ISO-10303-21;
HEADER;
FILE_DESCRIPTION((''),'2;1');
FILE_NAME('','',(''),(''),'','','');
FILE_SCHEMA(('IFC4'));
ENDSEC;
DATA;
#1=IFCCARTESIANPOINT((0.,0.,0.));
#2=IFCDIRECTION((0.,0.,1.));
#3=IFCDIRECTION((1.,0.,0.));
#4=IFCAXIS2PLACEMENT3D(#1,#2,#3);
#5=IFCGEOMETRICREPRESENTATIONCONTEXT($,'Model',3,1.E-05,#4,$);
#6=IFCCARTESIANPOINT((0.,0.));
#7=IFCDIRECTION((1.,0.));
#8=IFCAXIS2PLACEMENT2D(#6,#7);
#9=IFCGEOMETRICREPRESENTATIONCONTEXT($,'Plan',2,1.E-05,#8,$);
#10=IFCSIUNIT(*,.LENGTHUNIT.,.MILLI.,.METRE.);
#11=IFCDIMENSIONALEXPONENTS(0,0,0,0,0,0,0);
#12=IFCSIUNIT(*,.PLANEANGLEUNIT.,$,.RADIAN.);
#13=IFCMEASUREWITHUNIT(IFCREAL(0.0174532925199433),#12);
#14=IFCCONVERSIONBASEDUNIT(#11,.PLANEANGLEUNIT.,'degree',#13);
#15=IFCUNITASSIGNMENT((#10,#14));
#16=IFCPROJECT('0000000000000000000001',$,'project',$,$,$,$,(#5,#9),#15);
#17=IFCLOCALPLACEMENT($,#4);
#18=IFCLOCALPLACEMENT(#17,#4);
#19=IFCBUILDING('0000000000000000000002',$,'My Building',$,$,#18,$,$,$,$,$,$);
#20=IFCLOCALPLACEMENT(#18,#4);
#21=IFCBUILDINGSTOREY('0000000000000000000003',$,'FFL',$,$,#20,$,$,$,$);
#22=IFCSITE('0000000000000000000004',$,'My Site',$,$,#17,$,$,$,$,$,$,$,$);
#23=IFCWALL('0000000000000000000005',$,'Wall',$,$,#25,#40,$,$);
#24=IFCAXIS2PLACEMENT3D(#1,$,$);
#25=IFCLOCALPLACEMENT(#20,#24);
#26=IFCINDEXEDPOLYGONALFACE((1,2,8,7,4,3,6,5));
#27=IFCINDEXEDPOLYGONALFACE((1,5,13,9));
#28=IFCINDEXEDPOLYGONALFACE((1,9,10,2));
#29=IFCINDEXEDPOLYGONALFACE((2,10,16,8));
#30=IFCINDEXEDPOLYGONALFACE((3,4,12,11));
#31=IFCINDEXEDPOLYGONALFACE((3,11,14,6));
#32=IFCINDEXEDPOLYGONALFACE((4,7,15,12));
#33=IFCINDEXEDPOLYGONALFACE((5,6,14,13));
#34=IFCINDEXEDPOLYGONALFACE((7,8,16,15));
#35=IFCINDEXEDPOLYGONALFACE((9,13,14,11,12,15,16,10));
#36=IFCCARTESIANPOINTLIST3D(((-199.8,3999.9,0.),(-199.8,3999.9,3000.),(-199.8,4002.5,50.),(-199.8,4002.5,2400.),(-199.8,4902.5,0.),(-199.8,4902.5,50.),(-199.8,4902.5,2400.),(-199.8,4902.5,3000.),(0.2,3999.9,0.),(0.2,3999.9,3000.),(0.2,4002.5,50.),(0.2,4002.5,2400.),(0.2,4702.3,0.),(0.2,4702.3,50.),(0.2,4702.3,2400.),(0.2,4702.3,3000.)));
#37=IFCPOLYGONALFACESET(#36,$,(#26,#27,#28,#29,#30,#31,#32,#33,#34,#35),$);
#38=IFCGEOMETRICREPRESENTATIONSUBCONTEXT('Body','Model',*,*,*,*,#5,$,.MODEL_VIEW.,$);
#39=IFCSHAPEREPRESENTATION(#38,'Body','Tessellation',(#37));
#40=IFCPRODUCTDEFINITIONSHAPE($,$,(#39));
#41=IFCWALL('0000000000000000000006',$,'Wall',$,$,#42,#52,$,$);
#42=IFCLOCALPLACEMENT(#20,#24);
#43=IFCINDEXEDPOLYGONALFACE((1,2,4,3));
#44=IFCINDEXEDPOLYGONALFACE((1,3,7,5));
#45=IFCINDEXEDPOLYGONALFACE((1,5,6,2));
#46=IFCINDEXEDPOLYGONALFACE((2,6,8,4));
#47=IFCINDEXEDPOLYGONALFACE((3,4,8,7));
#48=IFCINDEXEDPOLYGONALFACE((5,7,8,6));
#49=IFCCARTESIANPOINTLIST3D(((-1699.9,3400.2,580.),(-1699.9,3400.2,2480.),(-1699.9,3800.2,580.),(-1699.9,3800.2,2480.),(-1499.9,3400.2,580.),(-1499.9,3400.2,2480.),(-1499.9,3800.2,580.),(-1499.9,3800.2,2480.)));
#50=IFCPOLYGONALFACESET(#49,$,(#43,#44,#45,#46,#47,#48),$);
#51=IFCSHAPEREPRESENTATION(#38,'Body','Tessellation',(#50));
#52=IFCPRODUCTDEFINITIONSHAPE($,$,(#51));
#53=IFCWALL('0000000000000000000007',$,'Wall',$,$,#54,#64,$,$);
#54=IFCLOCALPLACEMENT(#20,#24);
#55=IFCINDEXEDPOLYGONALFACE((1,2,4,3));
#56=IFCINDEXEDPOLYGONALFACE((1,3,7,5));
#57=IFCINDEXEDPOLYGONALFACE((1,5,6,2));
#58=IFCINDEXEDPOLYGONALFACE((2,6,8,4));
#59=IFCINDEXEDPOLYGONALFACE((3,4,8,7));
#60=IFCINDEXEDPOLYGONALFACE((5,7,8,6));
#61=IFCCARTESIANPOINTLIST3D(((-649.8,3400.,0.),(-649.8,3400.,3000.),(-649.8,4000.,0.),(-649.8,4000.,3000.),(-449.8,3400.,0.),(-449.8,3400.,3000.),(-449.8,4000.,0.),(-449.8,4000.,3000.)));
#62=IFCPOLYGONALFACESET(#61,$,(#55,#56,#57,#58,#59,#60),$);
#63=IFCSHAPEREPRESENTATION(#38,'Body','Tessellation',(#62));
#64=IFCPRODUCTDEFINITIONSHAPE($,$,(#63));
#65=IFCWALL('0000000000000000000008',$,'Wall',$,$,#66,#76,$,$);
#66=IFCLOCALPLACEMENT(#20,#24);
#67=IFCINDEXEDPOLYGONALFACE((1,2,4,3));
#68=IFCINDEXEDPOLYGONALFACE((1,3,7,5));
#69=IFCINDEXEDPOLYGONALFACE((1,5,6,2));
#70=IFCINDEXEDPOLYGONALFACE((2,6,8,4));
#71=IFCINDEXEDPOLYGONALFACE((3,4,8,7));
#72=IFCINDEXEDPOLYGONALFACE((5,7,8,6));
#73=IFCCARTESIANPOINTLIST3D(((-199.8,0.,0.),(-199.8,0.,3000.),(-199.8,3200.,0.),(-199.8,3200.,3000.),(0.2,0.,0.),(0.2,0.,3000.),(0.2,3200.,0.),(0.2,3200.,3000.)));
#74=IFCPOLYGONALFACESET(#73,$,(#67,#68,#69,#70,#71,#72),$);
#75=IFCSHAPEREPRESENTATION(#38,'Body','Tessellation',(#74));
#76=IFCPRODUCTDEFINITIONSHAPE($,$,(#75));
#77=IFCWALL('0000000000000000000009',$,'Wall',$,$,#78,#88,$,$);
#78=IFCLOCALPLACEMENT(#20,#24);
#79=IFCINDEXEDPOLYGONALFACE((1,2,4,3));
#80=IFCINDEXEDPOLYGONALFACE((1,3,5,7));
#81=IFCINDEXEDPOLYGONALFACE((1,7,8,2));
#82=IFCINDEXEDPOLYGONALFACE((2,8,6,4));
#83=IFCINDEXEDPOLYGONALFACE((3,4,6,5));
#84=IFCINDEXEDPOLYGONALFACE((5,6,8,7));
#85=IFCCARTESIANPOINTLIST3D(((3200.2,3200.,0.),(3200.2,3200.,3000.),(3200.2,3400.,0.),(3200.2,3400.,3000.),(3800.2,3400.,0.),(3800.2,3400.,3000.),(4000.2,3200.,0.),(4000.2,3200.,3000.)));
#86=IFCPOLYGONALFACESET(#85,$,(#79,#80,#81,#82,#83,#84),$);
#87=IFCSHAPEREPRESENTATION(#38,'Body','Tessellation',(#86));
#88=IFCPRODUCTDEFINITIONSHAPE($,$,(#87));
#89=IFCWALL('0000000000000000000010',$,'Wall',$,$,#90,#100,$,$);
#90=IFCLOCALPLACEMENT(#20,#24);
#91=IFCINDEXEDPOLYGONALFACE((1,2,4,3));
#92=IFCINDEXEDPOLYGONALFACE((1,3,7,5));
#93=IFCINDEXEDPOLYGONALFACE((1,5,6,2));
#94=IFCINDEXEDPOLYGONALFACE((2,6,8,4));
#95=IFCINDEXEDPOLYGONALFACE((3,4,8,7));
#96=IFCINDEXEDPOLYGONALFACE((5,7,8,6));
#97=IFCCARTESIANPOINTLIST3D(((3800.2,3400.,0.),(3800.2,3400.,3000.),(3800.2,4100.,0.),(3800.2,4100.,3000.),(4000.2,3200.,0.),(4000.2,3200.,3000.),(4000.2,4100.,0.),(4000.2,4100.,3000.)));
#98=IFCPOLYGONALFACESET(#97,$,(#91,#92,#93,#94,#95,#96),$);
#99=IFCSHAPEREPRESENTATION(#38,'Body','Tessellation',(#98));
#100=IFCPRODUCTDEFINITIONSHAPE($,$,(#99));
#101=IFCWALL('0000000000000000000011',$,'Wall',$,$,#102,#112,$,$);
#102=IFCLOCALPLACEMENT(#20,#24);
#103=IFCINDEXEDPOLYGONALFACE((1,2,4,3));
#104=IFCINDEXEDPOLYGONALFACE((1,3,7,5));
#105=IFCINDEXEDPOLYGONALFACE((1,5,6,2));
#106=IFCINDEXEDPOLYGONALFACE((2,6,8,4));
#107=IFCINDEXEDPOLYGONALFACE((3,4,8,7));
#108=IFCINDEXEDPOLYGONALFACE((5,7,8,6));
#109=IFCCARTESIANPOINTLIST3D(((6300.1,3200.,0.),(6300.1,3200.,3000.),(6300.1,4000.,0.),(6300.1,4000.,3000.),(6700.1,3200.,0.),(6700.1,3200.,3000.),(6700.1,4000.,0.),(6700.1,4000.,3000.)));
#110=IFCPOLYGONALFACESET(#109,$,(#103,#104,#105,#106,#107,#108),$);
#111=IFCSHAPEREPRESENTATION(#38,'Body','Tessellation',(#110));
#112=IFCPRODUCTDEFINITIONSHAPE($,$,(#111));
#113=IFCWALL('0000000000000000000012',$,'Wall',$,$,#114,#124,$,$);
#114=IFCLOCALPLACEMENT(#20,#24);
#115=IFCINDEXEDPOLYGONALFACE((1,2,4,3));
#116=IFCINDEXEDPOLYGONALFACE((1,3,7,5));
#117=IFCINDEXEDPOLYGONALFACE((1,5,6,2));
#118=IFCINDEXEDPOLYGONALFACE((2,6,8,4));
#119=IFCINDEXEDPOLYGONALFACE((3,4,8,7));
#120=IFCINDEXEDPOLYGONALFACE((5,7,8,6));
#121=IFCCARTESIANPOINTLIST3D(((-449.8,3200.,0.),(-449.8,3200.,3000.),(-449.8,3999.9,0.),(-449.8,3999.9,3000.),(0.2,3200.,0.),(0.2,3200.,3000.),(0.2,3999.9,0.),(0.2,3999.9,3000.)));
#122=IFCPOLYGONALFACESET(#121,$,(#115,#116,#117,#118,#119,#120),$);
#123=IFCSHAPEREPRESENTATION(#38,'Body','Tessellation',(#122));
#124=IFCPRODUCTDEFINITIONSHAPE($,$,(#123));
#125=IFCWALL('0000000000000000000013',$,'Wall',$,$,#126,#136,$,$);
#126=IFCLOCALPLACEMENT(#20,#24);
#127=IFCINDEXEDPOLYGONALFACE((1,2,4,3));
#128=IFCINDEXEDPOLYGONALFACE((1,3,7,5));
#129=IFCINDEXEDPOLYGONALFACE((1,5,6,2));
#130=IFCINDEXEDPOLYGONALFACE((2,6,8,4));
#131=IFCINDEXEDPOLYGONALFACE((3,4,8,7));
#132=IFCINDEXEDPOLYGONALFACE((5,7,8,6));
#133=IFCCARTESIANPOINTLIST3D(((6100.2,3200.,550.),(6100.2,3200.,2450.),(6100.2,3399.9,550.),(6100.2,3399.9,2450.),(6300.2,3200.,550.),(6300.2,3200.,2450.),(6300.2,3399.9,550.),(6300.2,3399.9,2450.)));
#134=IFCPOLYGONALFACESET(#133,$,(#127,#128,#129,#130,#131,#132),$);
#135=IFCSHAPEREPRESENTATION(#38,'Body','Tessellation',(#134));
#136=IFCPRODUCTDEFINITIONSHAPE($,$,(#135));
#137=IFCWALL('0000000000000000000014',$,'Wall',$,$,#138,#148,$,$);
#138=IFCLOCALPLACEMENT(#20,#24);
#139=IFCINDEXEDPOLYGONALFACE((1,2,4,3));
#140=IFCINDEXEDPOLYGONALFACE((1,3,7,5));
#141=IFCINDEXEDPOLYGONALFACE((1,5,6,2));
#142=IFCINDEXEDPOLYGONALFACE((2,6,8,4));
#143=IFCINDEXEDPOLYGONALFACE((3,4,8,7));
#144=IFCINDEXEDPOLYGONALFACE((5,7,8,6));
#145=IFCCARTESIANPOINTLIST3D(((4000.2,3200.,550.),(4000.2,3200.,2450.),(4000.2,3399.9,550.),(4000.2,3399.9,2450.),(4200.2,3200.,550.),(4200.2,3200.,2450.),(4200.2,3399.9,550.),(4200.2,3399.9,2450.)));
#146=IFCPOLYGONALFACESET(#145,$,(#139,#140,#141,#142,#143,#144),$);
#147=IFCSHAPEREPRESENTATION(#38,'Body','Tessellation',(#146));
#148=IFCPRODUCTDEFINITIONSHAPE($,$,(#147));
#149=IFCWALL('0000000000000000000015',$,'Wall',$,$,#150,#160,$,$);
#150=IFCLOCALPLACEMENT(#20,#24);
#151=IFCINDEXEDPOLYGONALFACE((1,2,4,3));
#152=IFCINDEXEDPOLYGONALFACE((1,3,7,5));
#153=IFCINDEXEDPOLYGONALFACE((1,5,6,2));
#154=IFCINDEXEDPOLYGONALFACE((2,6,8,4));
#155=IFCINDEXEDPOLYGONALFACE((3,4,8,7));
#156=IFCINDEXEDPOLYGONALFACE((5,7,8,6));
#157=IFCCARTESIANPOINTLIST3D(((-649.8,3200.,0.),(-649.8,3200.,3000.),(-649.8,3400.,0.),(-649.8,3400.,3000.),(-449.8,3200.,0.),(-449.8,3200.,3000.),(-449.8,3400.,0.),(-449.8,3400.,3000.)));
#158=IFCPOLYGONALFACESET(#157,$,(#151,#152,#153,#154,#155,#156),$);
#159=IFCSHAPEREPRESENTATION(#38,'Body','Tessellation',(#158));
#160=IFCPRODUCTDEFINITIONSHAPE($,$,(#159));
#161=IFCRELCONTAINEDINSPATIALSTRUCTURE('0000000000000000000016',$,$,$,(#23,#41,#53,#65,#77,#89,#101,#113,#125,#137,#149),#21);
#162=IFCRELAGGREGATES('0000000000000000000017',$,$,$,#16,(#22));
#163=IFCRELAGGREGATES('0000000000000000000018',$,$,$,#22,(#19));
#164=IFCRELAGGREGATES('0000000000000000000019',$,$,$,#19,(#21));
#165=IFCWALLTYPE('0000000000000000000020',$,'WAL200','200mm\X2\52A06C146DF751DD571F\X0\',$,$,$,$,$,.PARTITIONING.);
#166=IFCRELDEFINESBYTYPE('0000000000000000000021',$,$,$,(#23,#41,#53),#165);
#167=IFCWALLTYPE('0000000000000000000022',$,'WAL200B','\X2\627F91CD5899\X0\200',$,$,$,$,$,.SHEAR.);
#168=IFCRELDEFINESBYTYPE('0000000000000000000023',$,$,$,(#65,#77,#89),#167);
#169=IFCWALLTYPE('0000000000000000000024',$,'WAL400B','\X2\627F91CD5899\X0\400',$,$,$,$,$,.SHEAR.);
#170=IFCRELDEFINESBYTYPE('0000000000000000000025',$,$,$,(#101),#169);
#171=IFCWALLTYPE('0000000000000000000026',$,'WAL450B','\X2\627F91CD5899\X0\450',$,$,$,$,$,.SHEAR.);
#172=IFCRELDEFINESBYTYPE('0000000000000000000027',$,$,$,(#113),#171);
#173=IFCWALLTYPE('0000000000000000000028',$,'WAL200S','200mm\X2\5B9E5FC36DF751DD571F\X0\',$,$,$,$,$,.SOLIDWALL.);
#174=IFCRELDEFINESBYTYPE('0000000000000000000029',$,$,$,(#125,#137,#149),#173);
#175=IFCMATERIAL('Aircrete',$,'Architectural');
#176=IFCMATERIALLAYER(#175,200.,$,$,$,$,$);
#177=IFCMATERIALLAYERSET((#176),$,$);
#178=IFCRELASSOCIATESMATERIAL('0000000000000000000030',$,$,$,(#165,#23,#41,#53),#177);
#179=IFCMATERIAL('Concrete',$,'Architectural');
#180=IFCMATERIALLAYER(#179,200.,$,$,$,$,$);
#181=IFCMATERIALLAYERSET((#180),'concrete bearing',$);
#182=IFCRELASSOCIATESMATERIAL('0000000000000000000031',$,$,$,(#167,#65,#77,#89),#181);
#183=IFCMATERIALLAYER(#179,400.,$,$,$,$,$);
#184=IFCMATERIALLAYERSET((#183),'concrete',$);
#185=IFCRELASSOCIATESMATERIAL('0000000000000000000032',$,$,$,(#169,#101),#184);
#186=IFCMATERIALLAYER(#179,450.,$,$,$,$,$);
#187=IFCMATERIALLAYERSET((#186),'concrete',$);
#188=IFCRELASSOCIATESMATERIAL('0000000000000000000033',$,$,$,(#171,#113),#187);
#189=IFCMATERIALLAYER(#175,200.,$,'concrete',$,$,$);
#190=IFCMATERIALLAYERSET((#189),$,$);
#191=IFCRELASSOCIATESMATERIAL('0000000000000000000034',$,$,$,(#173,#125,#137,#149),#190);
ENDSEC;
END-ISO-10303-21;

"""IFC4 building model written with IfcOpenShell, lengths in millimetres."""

from ifc_helpers import new_model, entity, si_unit, converted_unit, frame, origin_with_axes, origin_2d_with_axis, place, context, subcontext, project, spatial, line, indexed_curve, outline, extrude, material, layer, layer_set, layer_usage, type_object, element, save


model = new_model("IFC4")

# Units and contexts
model_context = context("Model", 3, precision=1e-05, world=origin_with_axes())
plan_context = context("Plan", 2, precision=1e-05, world=origin_2d_with_axis())
body_context_1 = subcontext(model_context, "Body", "Model", "MODEL_VIEW")
ifc_project = project(units=[si_unit("LENGTHUNIT", "METRE", prefix="MILLI"), converted_unit("PLANEANGLEUNIT", "degree", entity("IfcReal", 0.0174532925199433), si_unit("PLANEANGLEUNIT", "RADIAN"), dimensions=[0, 0, 0, 0, 0, 0, 0])], contexts=[model_context, plan_context])

# Site, building, storey
site_placement = place(None, origin_with_axes())
site = spatial("IfcSite", under=ifc_project, at=site_placement, Name="My Site")
building_placement = place(site_placement, origin_with_axes())
building = spatial("IfcBuilding", under=site, at=building_placement, Name="My Building")
storey_placement = place(building_placement, origin_with_axes())
storey = spatial("IfcBuildingStorey", under=building, at=storey_placement, Name="FFL")

# Shared definitions
ifc_material_1 = material(Name="Aircrete", Category="Architectural")

# Shared definitions
ifc_layer_1 = layer(ifc_material_1, 200.0)
ifc_layer_set_1 = layer_set([ifc_layer_1])
wall_type_1 = type_object("IfcWallType", Name="WAL200", Description="200mm加气混凝土", PredefinedType="PARTITIONING", material=ifc_layer_set_1)

# Wall, opening
ifc_layer_usage_1 = layer_usage(ifc_layer_set_1, "AXIS2", "NEGATIVE", 0.0)
wall_1_placement = place(storey_placement, frame((-199.8, 3999.9, 0.0), z_axis=(0.0, 0.0, 1.0), x_axis=(0.000001, 1.0, 0.0)))
wall_1 = element("IfcWall", 1, at=wall_1_placement, inside=storey, type_object=wall_type_1, material=ifc_layer_usage_1, Name="Wall", context=body_context_1, shape_type="SweptSolid", body=[
    extrude(outline(indexed_curve([(0.0, -200.0), (0.0, 0.0), (902.5, 0.0), (702.4, -200.0)], segments=[line(1, 2, 3, 4, 1)])), origin_with_axes(), (0.0, 0.0, 1.0), 3000.0),
])
opening_1_placement = place(wall_1_placement, frame((2.6, 200.0, 50.0), z_axis=(0.0, 0.0, 1.0), x_axis=(0.0, -1.0, 0.0)))
element("IfcOpeningElement", 2, at=opening_1_placement, cuts=wall_1, PredefinedType="OPENING", context=body_context_1, shape_type="SweptSolid", body=[
    extrude(outline(indexed_curve([(0.0, 0.0), (4600.0, 0.0), (4600.0, 1146.7), (0.0, 1146.7), (0.0, 0.0)])), origin_with_axes(), (0.0, 0.0, 1.0), 2350.0),
])

# Walls
ifc_layer_usage_2 = layer_usage(ifc_layer_set_1, "AXIS2", "NEGATIVE", 0.0)
wall_2_placement = place(storey_placement, frame((-1699.9, 3400.2, 580.0), z_axis=(0.0, 0.0, 1.0), x_axis=(0.0, 1.0, 0.0)))
element("IfcWall", 3, at=wall_2_placement, inside=storey, type_object=wall_type_1, material=ifc_layer_usage_2, Name="Wall", context=body_context_1, shape_type="SweptSolid", body=[
    extrude(outline(indexed_curve([(0.0, -200.0), (0.0, 0.0), (400.0, 0.0), (400.0, -200.0)], segments=[line(1, 2, 3, 4, 1)])), origin_with_axes(), (0.0, 0.0, 1.0), 1900.0),
])
ifc_layer_usage_3 = layer_usage(ifc_layer_set_1, "AXIS2", "NEGATIVE", 0.0)
wall_3_placement = place(storey_placement, frame((-649.8, 3400.0, 0.0), z_axis=(0.0, 0.0, 1.0), x_axis=(0.0, 1.0, 0.0)))
element("IfcWall", 4, at=wall_3_placement, inside=storey, type_object=wall_type_1, material=ifc_layer_usage_3, Name="Wall", context=body_context_1, shape_type="SweptSolid", body=[
    extrude(outline(indexed_curve([(0.0, -200.0), (0.0, 0.0), (600.0, 0.0), (600.0, -200.0)], segments=[line(1, 2, 3, 4, 1)])), origin_with_axes(), (0.0, 0.0, 1.0), 3000.0),
])
ifc_material_2 = material(Name="Concrete", Category="Architectural")
ifc_layer_2 = layer(ifc_material_2, 200.0)
ifc_layer_set_2 = layer_set([ifc_layer_2], Name="concrete bearing")
ifc_layer_usage_4 = layer_usage(ifc_layer_set_2, "AXIS2", "NEGATIVE", 0.0)
wall_type_2 = type_object("IfcWallType", Name="WAL200B", Description="承重墙200", PredefinedType="SHEAR", material=ifc_layer_set_2)
wall_4_placement = place(storey_placement, frame((0.2, 3200.0, 0.0), z_axis=(0.0, 0.0, 1.0), x_axis=(0.0, -1.0, 0.0)))
element("IfcWall", 5, at=wall_4_placement, inside=storey, type_object=wall_type_2, material=ifc_layer_usage_4, Name="Wall", context=body_context_1, shape_type="SweptSolid", body=[
    extrude(outline(indexed_curve([(0.0, -200.0), (0.0, 0.0), (3200.0, 0.0), (3200.0, -200.0)], segments=[line(1, 2, 3, 4, 1)])), origin_with_axes(), (0.0, 0.0, 1.0), 3000.0),
])
ifc_layer_usage_5 = layer_usage(ifc_layer_set_2, "AXIS2", "NEGATIVE", 0.0)
wall_5_placement = place(storey_placement, frame((3800.2, 3200.0, 0.0), z_axis=(0.0, 0.0, 1.0), x_axis=(-1.0, 0.0, 0.0)))
element("IfcWall", 6, at=wall_5_placement, inside=storey, type_object=wall_type_2, material=ifc_layer_usage_5, Name="Wall", context=body_context_1, shape_type="SweptSolid", body=[
    extrude(outline(indexed_curve([(0.0, -200.0), (-200.0, 0.0), (600.0, 0.0), (600.0, -200.0)], segments=[line(1, 2, 3, 4, 1)])), origin_with_axes(), (0.0, 0.0, 1.0), 3000.0),
])
ifc_layer_usage_6 = layer_usage(ifc_layer_set_2, "AXIS2", "NEGATIVE", 0.0)
wall_6_placement = place(storey_placement, frame((3800.2, 3200.0, 0.0), z_axis=(0.0, 0.0, 1.0), x_axis=(0.0, 1.0, 0.0)))
element("IfcWall", 7, at=wall_6_placement, inside=storey, type_object=wall_type_2, material=ifc_layer_usage_6, Name="Wall", context=body_context_1, shape_type="SweptSolid", body=[
    extrude(outline(indexed_curve([(0.0, -200.0), (200.0, 0.0), (900.0, 0.0), (900.0, -200.0)], segments=[line(1, 2, 3, 4, 1)])), origin_with_axes(), (0.0, 0.0, 1.0), 3000.0),
])
ifc_layer_3 = layer(ifc_material_2, 400.0)
ifc_layer_set_3 = layer_set([ifc_layer_3], Name="concrete")
ifc_layer_usage_7 = layer_usage(ifc_layer_set_3, "AXIS2", "POSITIVE", 0.0)
wall_type_3 = type_object("IfcWallType", Name="WAL400B", Description="承重墙400", PredefinedType="SHEAR", material=ifc_layer_set_3)
wall_7_placement = place(storey_placement, frame((6700.1, 3200.0, 0.0), z_axis=(0.0, 0.0, 1.0), x_axis=(0.000001, 1.0, 0.0)))
element("IfcWall", 8, at=wall_7_placement, inside=storey, type_object=wall_type_3, material=ifc_layer_usage_7, Name="Wall", context=body_context_1, shape_type="SweptSolid", body=[
    extrude(outline(indexed_curve([(0.0, 0.0), (0.0, 400.0), (800.0, 400.0), (800.0, 0.0)], segments=[line(1, 2, 3, 4, 1)])), origin_with_axes(), (0.0, 0.0, 1.0), 3000.0),
])
ifc_layer_4 = layer(ifc_material_2, 450.0)
ifc_layer_set_4 = layer_set([ifc_layer_4], Name="concrete")
ifc_layer_usage_8 = layer_usage(ifc_layer_set_4, "AXIS2", "POSITIVE", 0.0)
wall_type_4 = type_object("IfcWallType", Name="WAL450B", Description="承重墙450", PredefinedType="SHEAR", material=ifc_layer_set_4)
wall_8_placement = place(storey_placement, frame((0.2, 3200.0, 0.0), z_axis=(0.0, 0.0, 1.0), x_axis=(0.0, 1.0, 0.0)))
element("IfcWall", 9, at=wall_8_placement, inside=storey, type_object=wall_type_4, material=ifc_layer_usage_8, Name="Wall", context=body_context_1, shape_type="SweptSolid", body=[
    extrude(outline(indexed_curve([(0.0, 0.0), (0.0, 450.0), (799.9, 450.0), (799.9, 0.0)], segments=[line(1, 2, 3, 4, 1)])), origin_with_axes(), (0.0, 0.0, 1.0), 3000.0),
])
ifc_layer_5 = layer(ifc_material_1, 200.0, Name="concrete")
ifc_layer_set_5 = layer_set([ifc_layer_5])
ifc_layer_usage_9 = layer_usage(ifc_layer_set_5, "AXIS2", "NEGATIVE", 0.0)
wall_type_5 = type_object("IfcWallType", Name="WAL200S", Description="200mm实心混凝土", PredefinedType="SOLIDWALL", material=ifc_layer_set_5)
wall_9_placement = place(storey_placement, frame((6100.2, 3200.0, 550.0), z_axis=(0.0, 0.0, 1.0), x_axis=(-0.000002, 1.0, 0.0)))
element("IfcWall", 10, at=wall_9_placement, inside=storey, type_object=wall_type_5, material=ifc_layer_usage_9, Name="Wall", context=body_context_1, shape_type="SweptSolid", body=[
    extrude(outline(indexed_curve([(0.0, -200.0), (0.0, 0.0), (200.0, 0.0), (200.0, -200.0)], segments=[line(1, 2, 3, 4, 1)])), origin_with_axes(), (0.0, 0.0, 1.0), 1900.0),
])
ifc_layer_usage_10 = layer_usage(ifc_layer_set_5, "AXIS2", "NEGATIVE", 0.0)
wall_10_placement = place(storey_placement, frame((4200.2, 3399.9, 550.0), z_axis=(0.0, 0.0, 1.0), x_axis=(0.000002, -1.0, 0.0)))
element("IfcWall", 11, at=wall_10_placement, inside=storey, type_object=wall_type_5, material=ifc_layer_usage_10, Name="Wall", context=body_context_1, shape_type="SweptSolid", body=[
    extrude(outline(indexed_curve([(0.0, -200.0), (0.0, 0.0), (200.0, 0.0), (200.0, -200.0)], segments=[line(1, 2, 3, 4, 1)])), origin_with_axes(), (0.0, 0.0, 1.0), 1900.0),
])
ifc_layer_usage_11 = layer_usage(ifc_layer_set_5, "AXIS2", "NEGATIVE", 0.0)
wall_11_placement = place(storey_placement, frame((-449.8, 3400.0, 0.0), z_axis=(0.0, 0.0, 1.0), x_axis=(0.000002, -1.0, 0.0)))
element("IfcWall", 12, at=wall_11_placement, inside=storey, type_object=wall_type_5, material=ifc_layer_usage_11, Name="Wall", context=body_context_1, shape_type="SweptSolid", body=[
    extrude(outline(indexed_curve([(0.0, -200.0), (0.0, 0.0), (200.0, 0.0), (200.0, -200.0)], segments=[line(1, 2, 3, 4, 1)])), origin_with_axes(), (0.0, 0.0, 1.0), 3000.0),
])

save(model, "model.ifc")
